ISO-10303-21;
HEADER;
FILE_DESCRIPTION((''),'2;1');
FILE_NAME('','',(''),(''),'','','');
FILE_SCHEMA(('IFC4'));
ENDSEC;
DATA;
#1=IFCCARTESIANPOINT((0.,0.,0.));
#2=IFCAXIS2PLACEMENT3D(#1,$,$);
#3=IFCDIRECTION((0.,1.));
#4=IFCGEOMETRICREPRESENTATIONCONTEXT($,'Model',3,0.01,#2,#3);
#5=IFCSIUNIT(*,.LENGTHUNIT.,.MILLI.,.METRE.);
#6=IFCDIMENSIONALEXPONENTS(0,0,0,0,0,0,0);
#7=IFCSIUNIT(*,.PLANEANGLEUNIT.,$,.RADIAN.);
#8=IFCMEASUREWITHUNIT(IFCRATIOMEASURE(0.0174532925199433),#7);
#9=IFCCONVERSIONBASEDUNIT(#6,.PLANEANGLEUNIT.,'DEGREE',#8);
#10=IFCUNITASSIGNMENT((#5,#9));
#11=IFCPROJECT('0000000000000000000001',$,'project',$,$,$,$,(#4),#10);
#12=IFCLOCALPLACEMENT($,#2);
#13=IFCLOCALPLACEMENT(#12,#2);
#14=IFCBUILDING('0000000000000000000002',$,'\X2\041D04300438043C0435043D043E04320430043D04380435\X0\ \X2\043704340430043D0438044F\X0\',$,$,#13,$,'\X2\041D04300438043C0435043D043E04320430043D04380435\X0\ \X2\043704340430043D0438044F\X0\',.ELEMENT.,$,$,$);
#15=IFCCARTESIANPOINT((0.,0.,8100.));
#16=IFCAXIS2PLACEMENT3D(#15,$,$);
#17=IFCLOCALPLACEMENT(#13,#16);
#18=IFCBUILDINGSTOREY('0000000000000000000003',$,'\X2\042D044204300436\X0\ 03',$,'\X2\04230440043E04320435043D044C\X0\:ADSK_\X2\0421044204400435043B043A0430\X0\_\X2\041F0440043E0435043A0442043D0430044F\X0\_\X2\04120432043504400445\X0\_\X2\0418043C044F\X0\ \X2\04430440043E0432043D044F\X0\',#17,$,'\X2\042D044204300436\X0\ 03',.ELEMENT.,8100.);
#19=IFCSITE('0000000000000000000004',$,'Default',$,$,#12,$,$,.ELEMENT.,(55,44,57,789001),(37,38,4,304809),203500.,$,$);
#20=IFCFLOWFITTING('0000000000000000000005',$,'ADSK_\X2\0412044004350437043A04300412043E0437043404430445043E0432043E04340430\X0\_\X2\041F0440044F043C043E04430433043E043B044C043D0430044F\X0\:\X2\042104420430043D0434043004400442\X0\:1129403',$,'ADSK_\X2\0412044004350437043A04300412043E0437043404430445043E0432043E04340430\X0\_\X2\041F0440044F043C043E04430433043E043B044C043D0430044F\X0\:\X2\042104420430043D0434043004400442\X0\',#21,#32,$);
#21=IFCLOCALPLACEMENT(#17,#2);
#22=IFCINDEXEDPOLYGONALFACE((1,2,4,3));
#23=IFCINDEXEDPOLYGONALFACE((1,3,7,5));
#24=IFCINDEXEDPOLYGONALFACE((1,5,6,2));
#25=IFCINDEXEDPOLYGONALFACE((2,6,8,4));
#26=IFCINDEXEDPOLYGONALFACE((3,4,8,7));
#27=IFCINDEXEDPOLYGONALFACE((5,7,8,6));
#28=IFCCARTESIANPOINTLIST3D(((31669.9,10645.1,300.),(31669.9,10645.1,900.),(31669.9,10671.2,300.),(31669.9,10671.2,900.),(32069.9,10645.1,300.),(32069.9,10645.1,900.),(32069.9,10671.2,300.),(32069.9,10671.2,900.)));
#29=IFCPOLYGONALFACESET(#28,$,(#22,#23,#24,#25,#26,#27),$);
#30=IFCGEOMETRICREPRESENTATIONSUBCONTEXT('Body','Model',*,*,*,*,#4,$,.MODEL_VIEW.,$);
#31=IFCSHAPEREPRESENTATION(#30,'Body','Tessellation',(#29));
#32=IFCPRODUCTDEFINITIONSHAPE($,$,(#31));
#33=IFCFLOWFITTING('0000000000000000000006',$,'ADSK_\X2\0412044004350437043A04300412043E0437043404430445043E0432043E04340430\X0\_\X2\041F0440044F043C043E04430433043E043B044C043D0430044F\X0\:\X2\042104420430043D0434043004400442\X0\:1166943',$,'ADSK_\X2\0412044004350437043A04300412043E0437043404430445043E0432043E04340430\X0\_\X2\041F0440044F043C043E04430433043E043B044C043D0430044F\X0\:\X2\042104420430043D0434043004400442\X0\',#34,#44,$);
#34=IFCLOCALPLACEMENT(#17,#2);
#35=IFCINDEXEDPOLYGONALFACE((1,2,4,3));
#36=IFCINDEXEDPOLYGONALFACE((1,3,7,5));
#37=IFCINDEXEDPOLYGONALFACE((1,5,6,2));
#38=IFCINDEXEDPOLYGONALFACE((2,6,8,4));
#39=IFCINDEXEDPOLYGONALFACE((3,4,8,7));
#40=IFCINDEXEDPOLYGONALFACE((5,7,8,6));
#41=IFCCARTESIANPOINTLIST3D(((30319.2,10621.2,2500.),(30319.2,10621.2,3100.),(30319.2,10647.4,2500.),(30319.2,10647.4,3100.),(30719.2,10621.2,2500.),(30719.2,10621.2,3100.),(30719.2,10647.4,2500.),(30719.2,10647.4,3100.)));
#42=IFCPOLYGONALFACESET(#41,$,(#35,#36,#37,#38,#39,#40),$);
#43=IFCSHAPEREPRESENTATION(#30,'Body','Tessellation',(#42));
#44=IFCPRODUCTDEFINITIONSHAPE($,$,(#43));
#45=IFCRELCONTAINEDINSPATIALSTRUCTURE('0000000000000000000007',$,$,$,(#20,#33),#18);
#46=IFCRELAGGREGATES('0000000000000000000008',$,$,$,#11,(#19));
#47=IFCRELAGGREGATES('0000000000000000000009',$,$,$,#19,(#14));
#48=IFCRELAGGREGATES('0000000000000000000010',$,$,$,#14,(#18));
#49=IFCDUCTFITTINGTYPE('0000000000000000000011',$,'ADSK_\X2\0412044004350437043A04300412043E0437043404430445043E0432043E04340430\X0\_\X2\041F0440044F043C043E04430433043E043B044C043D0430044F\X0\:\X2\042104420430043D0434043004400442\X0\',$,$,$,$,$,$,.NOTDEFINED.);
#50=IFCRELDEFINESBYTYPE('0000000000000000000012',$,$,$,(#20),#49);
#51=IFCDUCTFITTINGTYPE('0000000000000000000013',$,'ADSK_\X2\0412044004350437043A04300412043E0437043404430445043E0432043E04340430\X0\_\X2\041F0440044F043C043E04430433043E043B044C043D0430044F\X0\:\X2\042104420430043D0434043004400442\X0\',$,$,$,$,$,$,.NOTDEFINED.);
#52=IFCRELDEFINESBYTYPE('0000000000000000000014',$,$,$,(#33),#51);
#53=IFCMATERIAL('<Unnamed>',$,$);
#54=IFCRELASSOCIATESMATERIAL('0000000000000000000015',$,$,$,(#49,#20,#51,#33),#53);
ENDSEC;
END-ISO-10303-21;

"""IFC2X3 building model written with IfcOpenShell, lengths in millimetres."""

from ifc_helpers import new_model, entity, si_unit, converted_unit, direction, frame, origin, origin_2d_with_axis, place, context, subcontext, project, spatial, rectangle, extrude, source, transform, mapped, material, type_object, type_shapes, element, save


model = new_model("IFC2X3")

# Units and contexts
model_context = context("Model", 3, precision=0.01, world=origin(), true_north=direction((0.0, 1.0)))
body_context = subcontext(model_context, "Body", "Model", "MODEL_VIEW")
ifc_project = project(units=[si_unit("LENGTHUNIT", "METRE", prefix="MILLI"), converted_unit("PLANEANGLEUNIT", "DEGREE", entity("IfcRatioMeasure", 0.0174532925199433), si_unit("PLANEANGLEUNIT", "RADIAN"), dimensions=[0, 0, 0, 0, 0, 0, 0])], contexts=[model_context])

# Site, building, storey
site_placement = place(None, origin())
site = spatial("IfcSite", under=ifc_project, at=site_placement, Name="Default", CompositionType="ELEMENT", RefLatitude=(55, 44, 57, 789001), RefLongitude=(37, 38, 4, 304809), RefElevation=203500.0)
building_placement = place(site_placement, origin())
building = spatial("IfcBuilding", under=site, at=building_placement, Name="Наименование здания", LongName="Наименование здания", CompositionType="ELEMENT")
storey_placement = place(building_placement, frame((0.0, 0.0, 8100.0)))
storey = spatial("IfcBuildingStorey", under=building, at=storey_placement, Name="Этаж 03", ObjectType="Уровень:ADSK_Стрелка_Проектная_Вверх_Имя уровня", LongName="Этаж 03", CompositionType="ELEMENT", Elevation=8100.0)

# Shared definitions
ifc_material_1 = material(Name="<Unnamed>")

# Flow fittings
duct_fitting_type_1 = type_object("IfcDuctFittingType", Name="ADSK_ВрезкаВоздуховода_Прямоугольная:Стандарт", PredefinedType="NOTDEFINED", material=ifc_material_1)
shared_shape_1 = source(origin(), body_context, "Body", "SweptSolid", [
    extrude(rectangle(XDim=600.0, YDim=26.1, at=origin_2d_with_axis()), frame((7.0, 0.0, -200.0), z_axis=(0.0, 0.0, 1.0), x_axis=(0.0, -1.0, 0.0)), (0.0, 0.0, 1.0), 400.0),
])
type_shapes(duct_fitting_type_1, [shared_shape_1])
flow_fitting_1_placement = place(storey_placement, frame((31869.9, 10665.1, 600.0), z_axis=(-1.0, -0.000236, 0.0), x_axis=(0.000236, -1.0, 0.0)))
element("IfcFlowFitting", 1, at=flow_fitting_1_placement, inside=storey, type_object=duct_fitting_type_1, material=ifc_material_1, Name="ADSK_ВрезкаВоздуховода_Прямоугольная:Стандарт:1129403", ObjectType="ADSK_ВрезкаВоздуховода_Прямоугольная:Стандарт", context=body_context, shape_type="MappedRepresentation", body=[
    mapped(shared_shape_1, transform((0.0, 0.0, 0.0), scale=1.0)),
])
duct_fitting_type_2 = type_object("IfcDuctFittingType", Name="ADSK_ВрезкаВоздуховода_Прямоугольная:Стандарт", PredefinedType="NOTDEFINED", material=ifc_material_1)
shared_shape_2 = source(origin(), body_context, "Body", "SweptSolid", [
    extrude(rectangle(XDim=26.2, YDim=600.0, at=origin_2d_with_axis()), frame((6.9, 0.0, -200.0)), (0.0, 0.0, 1.0), 400.0),
])
type_shapes(duct_fitting_type_2, [shared_shape_2])
flow_fitting_2_placement = place(storey_placement, frame((30519.2, 10641.2, 2800.0), z_axis=(-1.0, 0.0, 0.0), x_axis=(0.0, -1.0, 0.0)))
element("IfcFlowFitting", 2, at=flow_fitting_2_placement, inside=storey, type_object=duct_fitting_type_2, material=ifc_material_1, Name="ADSK_ВрезкаВоздуховода_Прямоугольная:Стандарт:1166943", ObjectType="ADSK_ВрезкаВоздуховода_Прямоугольная:Стандарт", context=body_context, shape_type="MappedRepresentation", body=[
    mapped(shared_shape_2, transform((0.0, 0.0, 0.0), scale=1.0)),
])

save(model, "model.ifc")
